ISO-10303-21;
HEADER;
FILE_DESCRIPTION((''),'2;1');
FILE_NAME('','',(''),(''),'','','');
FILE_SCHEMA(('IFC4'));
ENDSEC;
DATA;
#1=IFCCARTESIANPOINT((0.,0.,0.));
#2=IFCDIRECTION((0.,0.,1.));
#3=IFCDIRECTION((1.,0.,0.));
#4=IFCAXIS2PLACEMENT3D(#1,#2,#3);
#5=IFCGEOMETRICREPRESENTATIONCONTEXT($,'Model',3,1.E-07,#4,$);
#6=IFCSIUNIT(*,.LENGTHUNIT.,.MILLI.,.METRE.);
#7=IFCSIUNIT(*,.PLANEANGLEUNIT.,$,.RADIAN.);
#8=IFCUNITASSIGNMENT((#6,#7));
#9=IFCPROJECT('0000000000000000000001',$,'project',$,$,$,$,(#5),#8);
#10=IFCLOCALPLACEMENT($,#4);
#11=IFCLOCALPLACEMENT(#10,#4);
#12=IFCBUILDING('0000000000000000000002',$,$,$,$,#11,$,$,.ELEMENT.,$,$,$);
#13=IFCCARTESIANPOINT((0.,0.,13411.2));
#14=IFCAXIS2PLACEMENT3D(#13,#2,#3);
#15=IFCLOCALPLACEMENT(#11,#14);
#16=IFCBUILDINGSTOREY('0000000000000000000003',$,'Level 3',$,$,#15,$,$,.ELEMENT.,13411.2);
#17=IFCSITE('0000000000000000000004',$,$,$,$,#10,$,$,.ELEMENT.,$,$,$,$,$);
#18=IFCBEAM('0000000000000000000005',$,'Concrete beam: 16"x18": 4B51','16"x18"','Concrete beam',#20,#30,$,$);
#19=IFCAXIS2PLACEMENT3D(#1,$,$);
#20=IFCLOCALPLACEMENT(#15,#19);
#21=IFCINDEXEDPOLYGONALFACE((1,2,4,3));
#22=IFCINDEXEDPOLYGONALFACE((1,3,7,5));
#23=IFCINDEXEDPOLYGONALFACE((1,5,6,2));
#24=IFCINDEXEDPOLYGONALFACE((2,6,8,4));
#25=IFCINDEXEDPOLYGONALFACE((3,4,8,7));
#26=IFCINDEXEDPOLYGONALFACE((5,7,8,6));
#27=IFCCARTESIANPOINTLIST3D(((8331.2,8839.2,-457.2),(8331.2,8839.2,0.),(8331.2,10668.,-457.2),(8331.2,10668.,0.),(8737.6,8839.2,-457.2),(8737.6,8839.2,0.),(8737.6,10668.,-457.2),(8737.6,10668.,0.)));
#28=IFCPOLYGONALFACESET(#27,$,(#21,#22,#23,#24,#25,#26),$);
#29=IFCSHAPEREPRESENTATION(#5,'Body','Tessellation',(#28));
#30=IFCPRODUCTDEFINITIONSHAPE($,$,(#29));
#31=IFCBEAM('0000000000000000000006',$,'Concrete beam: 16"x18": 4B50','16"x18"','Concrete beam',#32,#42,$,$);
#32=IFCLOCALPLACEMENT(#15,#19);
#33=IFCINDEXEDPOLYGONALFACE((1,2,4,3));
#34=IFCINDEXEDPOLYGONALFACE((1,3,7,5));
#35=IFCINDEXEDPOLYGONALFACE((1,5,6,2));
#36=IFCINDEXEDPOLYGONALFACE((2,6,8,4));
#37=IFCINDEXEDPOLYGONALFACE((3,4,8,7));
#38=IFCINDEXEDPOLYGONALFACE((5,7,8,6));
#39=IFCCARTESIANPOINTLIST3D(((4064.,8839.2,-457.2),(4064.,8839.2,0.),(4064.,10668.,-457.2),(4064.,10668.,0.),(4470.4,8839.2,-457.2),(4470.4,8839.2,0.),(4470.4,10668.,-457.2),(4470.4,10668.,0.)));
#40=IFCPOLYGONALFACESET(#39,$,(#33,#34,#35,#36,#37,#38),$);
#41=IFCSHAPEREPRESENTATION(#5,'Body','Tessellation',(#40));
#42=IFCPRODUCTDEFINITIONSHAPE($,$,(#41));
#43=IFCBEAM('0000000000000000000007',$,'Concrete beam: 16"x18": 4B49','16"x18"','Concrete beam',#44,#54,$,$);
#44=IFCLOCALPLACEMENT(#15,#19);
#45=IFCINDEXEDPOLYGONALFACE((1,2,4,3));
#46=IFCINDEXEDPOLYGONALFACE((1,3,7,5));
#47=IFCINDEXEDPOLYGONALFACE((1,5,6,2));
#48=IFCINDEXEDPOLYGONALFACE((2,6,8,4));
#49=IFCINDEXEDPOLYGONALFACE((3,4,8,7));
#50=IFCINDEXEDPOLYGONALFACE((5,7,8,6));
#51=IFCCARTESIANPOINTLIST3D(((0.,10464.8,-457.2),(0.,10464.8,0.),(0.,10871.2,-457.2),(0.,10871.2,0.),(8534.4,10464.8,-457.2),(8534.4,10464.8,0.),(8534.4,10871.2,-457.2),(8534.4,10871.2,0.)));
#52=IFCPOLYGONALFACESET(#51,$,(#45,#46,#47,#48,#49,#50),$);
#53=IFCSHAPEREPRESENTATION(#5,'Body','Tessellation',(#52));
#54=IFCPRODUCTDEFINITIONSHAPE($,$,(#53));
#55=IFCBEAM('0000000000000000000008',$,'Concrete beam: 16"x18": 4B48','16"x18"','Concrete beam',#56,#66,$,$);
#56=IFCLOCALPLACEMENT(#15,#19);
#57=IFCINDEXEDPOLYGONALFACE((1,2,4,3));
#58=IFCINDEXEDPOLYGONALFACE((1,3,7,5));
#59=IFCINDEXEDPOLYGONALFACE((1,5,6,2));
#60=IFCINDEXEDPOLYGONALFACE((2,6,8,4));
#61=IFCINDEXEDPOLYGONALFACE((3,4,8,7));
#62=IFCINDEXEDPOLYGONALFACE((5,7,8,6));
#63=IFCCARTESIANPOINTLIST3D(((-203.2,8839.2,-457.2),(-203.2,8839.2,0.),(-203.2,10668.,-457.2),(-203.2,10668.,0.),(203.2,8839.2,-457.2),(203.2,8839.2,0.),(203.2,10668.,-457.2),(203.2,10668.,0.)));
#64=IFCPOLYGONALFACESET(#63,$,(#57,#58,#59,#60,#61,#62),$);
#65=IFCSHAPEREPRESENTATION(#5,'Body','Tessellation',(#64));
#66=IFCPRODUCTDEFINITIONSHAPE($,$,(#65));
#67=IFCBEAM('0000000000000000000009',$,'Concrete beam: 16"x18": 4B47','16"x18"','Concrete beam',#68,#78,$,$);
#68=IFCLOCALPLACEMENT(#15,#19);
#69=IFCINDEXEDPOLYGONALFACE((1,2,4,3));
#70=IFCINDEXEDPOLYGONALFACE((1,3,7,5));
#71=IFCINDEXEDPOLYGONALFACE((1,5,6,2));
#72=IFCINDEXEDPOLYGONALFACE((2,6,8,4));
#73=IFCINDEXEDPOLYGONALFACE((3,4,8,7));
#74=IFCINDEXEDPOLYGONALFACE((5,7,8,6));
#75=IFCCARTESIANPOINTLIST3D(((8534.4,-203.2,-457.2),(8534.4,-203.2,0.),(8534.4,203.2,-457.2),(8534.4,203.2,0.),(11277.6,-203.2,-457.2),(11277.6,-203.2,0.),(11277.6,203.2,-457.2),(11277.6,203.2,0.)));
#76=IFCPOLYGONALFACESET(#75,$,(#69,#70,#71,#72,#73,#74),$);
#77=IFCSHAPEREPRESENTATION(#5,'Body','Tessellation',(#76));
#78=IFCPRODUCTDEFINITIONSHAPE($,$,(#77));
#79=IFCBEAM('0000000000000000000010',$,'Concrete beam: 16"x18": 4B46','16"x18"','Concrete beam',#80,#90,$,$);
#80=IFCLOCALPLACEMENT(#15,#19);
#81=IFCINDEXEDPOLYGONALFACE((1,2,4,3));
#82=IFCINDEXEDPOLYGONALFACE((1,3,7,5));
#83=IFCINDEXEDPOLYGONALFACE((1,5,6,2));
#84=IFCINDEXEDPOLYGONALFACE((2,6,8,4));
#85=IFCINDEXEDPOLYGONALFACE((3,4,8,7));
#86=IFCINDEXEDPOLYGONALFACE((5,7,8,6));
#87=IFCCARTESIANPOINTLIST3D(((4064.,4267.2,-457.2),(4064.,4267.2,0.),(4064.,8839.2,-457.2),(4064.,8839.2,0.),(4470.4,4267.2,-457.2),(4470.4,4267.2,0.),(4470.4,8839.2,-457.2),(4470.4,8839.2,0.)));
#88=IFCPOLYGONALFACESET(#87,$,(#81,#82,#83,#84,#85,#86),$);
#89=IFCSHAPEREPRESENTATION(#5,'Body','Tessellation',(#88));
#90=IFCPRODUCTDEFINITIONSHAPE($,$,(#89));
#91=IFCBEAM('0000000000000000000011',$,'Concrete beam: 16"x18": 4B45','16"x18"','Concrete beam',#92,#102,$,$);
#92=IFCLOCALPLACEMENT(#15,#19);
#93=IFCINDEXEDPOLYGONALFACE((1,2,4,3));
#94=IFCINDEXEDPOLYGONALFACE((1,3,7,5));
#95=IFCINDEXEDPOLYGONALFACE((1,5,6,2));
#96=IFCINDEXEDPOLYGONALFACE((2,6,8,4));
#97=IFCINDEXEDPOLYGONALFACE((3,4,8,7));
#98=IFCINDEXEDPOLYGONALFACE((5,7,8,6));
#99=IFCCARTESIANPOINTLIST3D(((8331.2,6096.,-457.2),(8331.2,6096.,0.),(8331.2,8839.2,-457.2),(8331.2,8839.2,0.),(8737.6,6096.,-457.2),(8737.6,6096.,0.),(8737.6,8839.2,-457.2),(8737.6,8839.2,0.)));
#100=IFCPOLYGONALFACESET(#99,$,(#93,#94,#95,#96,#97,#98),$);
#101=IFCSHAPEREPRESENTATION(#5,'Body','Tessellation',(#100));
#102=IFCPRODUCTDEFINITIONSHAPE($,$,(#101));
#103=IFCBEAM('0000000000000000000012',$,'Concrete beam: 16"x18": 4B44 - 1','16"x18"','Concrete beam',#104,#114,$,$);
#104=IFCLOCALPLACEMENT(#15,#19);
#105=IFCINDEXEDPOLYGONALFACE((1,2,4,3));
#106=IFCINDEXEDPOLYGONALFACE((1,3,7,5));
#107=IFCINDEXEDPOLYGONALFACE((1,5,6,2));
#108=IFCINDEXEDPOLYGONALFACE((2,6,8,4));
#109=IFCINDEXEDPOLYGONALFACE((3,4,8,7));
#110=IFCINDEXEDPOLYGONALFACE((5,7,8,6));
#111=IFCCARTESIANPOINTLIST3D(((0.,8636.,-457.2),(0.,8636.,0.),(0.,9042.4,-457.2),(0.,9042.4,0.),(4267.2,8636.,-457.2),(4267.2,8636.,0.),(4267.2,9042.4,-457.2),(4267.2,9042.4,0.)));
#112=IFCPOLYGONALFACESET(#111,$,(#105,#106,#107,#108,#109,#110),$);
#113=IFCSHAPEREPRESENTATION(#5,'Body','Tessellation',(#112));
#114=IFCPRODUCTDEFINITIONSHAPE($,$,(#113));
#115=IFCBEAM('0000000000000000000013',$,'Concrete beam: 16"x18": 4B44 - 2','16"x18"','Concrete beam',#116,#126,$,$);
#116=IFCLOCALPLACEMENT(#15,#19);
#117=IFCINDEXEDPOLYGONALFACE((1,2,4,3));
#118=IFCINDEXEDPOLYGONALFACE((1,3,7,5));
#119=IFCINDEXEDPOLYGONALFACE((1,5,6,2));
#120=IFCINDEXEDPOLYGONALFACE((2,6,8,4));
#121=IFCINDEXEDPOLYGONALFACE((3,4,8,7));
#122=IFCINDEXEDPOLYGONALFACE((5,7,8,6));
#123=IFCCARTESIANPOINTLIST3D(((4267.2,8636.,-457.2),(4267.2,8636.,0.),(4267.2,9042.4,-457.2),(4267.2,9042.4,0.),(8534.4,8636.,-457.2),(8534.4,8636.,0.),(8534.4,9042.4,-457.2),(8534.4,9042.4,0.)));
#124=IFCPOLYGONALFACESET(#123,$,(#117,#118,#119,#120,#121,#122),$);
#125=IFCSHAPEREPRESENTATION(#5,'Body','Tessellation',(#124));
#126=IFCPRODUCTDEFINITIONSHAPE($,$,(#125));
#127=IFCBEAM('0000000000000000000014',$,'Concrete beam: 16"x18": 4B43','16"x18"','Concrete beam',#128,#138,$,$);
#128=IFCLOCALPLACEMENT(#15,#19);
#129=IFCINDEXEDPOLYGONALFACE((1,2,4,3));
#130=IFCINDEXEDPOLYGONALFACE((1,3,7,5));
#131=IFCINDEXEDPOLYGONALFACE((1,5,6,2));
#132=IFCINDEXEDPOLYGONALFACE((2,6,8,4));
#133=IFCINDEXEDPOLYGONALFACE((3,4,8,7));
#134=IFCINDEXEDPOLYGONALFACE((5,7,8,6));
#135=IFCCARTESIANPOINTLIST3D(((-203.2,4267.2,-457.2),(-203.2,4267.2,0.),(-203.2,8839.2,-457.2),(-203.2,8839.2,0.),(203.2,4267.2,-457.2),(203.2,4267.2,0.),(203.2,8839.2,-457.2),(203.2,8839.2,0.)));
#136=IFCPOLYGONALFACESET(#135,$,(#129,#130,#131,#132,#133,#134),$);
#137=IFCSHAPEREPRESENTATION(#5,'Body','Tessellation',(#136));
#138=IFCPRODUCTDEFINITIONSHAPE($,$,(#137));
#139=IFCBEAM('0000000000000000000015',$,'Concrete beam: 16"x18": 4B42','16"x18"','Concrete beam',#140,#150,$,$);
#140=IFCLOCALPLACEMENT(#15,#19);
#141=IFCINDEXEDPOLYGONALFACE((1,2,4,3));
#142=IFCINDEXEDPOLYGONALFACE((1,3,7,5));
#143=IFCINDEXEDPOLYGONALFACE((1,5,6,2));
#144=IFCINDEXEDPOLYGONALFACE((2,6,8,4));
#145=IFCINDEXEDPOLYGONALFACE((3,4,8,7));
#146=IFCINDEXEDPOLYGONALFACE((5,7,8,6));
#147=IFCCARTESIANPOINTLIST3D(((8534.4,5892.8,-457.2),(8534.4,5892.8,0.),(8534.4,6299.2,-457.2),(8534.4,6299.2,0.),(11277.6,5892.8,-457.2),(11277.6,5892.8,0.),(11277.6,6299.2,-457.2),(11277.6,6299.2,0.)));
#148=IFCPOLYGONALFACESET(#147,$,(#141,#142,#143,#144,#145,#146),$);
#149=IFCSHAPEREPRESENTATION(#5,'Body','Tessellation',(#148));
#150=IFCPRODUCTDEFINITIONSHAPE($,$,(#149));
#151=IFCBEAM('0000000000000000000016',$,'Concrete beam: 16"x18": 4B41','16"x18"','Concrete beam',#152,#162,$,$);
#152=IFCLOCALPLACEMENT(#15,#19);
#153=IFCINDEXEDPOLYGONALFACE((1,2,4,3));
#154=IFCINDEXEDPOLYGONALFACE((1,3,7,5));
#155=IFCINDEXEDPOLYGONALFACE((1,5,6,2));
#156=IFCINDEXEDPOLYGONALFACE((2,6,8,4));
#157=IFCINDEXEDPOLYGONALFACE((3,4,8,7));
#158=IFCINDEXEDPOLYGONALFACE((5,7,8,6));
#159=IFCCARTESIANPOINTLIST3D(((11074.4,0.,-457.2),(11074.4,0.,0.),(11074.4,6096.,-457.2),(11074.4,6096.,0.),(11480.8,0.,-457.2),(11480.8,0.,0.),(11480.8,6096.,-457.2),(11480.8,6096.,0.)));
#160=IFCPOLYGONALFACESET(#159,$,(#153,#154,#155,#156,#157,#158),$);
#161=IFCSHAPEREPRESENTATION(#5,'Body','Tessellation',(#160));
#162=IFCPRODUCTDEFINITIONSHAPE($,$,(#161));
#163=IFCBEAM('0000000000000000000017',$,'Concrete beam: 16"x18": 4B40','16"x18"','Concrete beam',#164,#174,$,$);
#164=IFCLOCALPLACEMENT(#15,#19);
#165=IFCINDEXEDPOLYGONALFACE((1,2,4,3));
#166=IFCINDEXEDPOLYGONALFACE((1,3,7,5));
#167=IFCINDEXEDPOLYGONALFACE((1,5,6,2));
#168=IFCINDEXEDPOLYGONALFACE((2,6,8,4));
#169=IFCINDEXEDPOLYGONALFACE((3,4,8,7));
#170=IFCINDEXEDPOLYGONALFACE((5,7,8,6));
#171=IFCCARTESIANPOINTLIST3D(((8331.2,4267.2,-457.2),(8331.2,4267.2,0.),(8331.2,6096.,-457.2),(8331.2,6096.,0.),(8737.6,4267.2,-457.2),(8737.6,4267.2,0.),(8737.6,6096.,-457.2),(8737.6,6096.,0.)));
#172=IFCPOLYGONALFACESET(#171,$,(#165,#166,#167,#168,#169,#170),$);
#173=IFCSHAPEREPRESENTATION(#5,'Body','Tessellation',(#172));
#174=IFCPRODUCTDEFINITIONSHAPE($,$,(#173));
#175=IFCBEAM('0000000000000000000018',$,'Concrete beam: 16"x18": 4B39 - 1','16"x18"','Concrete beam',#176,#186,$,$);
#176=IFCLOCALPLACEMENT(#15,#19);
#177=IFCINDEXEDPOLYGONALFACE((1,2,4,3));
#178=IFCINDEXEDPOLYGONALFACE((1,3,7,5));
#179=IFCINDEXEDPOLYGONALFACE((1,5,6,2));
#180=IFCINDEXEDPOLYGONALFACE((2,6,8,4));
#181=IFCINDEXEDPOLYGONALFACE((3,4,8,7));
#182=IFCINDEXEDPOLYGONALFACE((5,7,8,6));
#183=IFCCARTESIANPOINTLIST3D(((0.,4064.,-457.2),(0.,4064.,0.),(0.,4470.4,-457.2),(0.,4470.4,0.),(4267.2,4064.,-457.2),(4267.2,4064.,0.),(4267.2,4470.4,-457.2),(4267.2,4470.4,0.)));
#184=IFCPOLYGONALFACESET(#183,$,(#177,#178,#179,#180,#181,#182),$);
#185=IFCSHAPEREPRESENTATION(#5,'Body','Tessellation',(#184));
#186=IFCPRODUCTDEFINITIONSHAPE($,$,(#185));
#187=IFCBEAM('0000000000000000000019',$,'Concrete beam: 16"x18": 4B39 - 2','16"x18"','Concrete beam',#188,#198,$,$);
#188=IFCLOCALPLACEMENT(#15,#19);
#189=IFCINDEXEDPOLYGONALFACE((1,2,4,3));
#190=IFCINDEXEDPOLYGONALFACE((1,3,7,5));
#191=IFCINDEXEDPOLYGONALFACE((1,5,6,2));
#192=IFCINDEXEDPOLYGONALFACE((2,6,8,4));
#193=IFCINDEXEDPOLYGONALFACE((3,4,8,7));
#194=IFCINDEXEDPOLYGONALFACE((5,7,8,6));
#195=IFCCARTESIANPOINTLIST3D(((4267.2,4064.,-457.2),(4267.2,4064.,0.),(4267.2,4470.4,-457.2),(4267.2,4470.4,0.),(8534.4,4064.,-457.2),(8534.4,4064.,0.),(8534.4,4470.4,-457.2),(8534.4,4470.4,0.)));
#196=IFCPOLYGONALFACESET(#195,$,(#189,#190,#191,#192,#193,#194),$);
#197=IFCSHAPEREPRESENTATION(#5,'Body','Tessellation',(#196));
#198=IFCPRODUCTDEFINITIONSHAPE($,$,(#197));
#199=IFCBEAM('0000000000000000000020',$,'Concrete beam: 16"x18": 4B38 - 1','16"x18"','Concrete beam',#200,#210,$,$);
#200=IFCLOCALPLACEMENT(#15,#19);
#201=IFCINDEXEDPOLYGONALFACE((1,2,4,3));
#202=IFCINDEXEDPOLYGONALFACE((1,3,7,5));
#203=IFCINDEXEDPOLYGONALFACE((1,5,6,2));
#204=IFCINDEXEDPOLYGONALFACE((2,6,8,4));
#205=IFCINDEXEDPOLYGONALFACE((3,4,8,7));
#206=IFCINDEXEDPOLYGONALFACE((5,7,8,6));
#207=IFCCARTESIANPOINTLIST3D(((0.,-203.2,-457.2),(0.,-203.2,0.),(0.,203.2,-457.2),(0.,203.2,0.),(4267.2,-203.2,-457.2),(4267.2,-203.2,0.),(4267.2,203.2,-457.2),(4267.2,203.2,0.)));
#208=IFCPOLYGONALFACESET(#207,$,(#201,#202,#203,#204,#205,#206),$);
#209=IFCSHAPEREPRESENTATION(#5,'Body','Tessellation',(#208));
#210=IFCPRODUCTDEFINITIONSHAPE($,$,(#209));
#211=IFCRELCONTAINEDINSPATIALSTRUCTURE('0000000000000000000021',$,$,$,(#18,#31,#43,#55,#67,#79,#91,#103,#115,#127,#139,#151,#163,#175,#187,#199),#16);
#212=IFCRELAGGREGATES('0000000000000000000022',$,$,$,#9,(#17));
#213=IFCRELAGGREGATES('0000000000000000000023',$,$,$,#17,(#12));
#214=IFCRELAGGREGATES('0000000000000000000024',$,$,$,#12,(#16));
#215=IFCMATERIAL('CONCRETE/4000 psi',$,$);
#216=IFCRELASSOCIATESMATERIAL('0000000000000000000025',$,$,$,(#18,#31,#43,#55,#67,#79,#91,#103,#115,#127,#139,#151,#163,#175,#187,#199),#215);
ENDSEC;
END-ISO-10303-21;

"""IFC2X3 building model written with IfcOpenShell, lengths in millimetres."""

from ifc_helpers import new_model, si_unit, frame, origin_with_axes, origin_2d_with_axis, place, context, project, spatial, rectangle, extrude, material, element, save


model = new_model("IFC2X3")

# Units and contexts
model_context = context("Model", 3, precision=1e-07, world=origin_with_axes())
ifc_project = project(units=[si_unit("LENGTHUNIT", "METRE", prefix="MILLI"), si_unit("PLANEANGLEUNIT", "RADIAN")], contexts=[model_context])

# Site, building, storey
site_placement = place(None, origin_with_axes())
site = spatial("IfcSite", under=ifc_project, at=site_placement, CompositionType="ELEMENT")
building_placement = place(site_placement, origin_with_axes())
building = spatial("IfcBuilding", under=site, at=building_placement, CompositionType="ELEMENT")
storey_placement = place(building_placement, frame((0.0, 0.0, 13411.2), z_axis=(0.0, 0.0, 1.0), x_axis=(1.0, 0.0, 0.0)))
storey = spatial("IfcBuildingStorey", under=building, at=storey_placement, Name="Level 3", CompositionType="ELEMENT", Elevation=13411.2)

# Beams
ifc_material = material(Name="CONCRETE/4000 psi")
for number, where, z_axis, x_axis, name in (
    (1, (8534.4, 10668.0, 13411.2), (0.0, 0.0, 1.0), (0.0, -1.0, 0.0), "Concrete beam: 16\"x18\": 4B51"),
    (2, (4267.2, 10668.0, 13411.2), (0.0, 0.0, 1.0), (0.0, -1.0, 0.0), "Concrete beam: 16\"x18\": 4B50"),
):
    element("IfcBeam", number, at=place(building_placement, frame(where, z_axis=z_axis, x_axis=x_axis)), inside=storey, material=ifc_material, Name=name, Description="16\"x18\"", ObjectType="Concrete beam", context=model_context, shape_type="SweptSolid", body=[
        extrude(rectangle(XDim=406.4, YDim=457.2, at=origin_2d_with_axis()), frame((1828.8, 0.0, -228.6), z_axis=(-1.0, 0.0, 0.0), x_axis=(0.0, -1.0, 0.0)), (0.0, 0.0, 1.0), 1828.8),
    ])
beam_1_placement = place(building_placement, frame((0.0, 10668.0, 13411.2), z_axis=(0.0, 0.0, 1.0), x_axis=(1.0, 0.0, 0.0)))
element("IfcBeam", 3, at=beam_1_placement, inside=storey, material=ifc_material, Name="Concrete beam: 16\"x18\": 4B49", Description="16\"x18\"", ObjectType="Concrete beam", context=model_context, shape_type="SweptSolid", body=[
    extrude(rectangle(XDim=406.4, YDim=457.2, at=origin_2d_with_axis()), frame((8534.4, 0.0, -228.6), z_axis=(-1.0, 0.0, 0.0), x_axis=(0.0, -1.0, 0.0)), (0.0, 0.0, 1.0), 8534.4),
])
beam_2_placement = place(building_placement, frame((0.0, 10668.0, 13411.2), z_axis=(0.0, 0.0, 1.0), x_axis=(0.0, -1.0, 0.0)))
element("IfcBeam", 4, at=beam_2_placement, inside=storey, material=ifc_material, Name="Concrete beam: 16\"x18\": 4B48", Description="16\"x18\"", ObjectType="Concrete beam", context=model_context, shape_type="SweptSolid", body=[
    extrude(rectangle(XDim=406.4, YDim=457.2, at=origin_2d_with_axis()), frame((1828.8, 0.0, -228.6), z_axis=(-1.0, 0.0, 0.0), x_axis=(0.0, -1.0, 0.0)), (0.0, 0.0, 1.0), 1828.8),
])
beam_3_placement = place(building_placement, frame((8534.4, 0.0, 13411.2), z_axis=(0.0, 0.0, 1.0), x_axis=(1.0, 0.0, 0.0)))
element("IfcBeam", 5, at=beam_3_placement, inside=storey, material=ifc_material, Name="Concrete beam: 16\"x18\": 4B47", Description="16\"x18\"", ObjectType="Concrete beam", context=model_context, shape_type="SweptSolid", body=[
    extrude(rectangle(XDim=406.4, YDim=457.2, at=origin_2d_with_axis()), frame((2743.2, 0.0, -228.6), z_axis=(-1.0, 0.0, 0.0), x_axis=(0.0, -1.0, 0.0)), (0.0, 0.0, 1.0), 2743.2),
])
beam_4_placement = place(building_placement, frame((4267.2, 4267.2, 13411.2), z_axis=(0.0, 0.0, 1.0), x_axis=(0.0, 1.0, 0.0)))
element("IfcBeam", 6, at=beam_4_placement, inside=storey, material=ifc_material, Name="Concrete beam: 16\"x18\": 4B46", Description="16\"x18\"", ObjectType="Concrete beam", context=model_context, shape_type="SweptSolid", body=[
    extrude(rectangle(XDim=406.4, YDim=457.2, at=origin_2d_with_axis()), frame((4572.0, 0.0, -228.6), z_axis=(-1.0, 0.0, 0.0), x_axis=(0.0, -1.0, 0.0)), (0.0, 0.0, 1.0), 4572.0),
])
beam_5_placement = place(building_placement, frame((8534.4, 6096.0, 13411.2), z_axis=(0.0, 0.0, 1.0), x_axis=(0.0, 1.0, 0.0)))
element("IfcBeam", 7, at=beam_5_placement, inside=storey, material=ifc_material, Name="Concrete beam: 16\"x18\": 4B45", Description="16\"x18\"", ObjectType="Concrete beam", context=model_context, shape_type="SweptSolid", body=[
    extrude(rectangle(XDim=406.4, YDim=457.2, at=origin_2d_with_axis()), frame((2743.2, 0.0, -228.6), z_axis=(-1.0, 0.0, 0.0), x_axis=(0.0, -1.0, 0.0)), (0.0, 0.0, 1.0), 2743.2),
])
for number, where, z_axis, x_axis, name in (
    (8, (0.0, 8839.2, 13411.2), (0.0, 0.0, 1.0), (1.0, 0.0, 0.0), "Concrete beam: 16\"x18\": 4B44 - 1"),
    (9, (4267.2, 8839.2, 13411.2), (0.0, 0.0, 1.0), (1.0, 0.0, 0.0), "Concrete beam: 16\"x18\": 4B44 - 2"),
):
    element("IfcBeam", number, at=place(building_placement, frame(where, z_axis=z_axis, x_axis=x_axis)), inside=storey, material=ifc_material, Name=name, Description="16\"x18\"", ObjectType="Concrete beam", context=model_context, shape_type="SweptSolid", body=[
        extrude(rectangle(XDim=406.4, YDim=457.2, at=origin_2d_with_axis()), frame((4267.2, 0.0, -228.6), z_axis=(-1.0, 0.0, 0.0), x_axis=(0.0, -1.0, 0.0)), (0.0, 0.0, 1.0), 4267.2),
    ])
beam_6_placement = place(building_placement, frame((0.0, 4267.2, 13411.2), z_axis=(0.0, 0.0, 1.0), x_axis=(0.0, 1.0, 0.0)))
element("IfcBeam", 10, at=beam_6_placement, inside=storey, material=ifc_material, Name="Concrete beam: 16\"x18\": 4B43", Description="16\"x18\"", ObjectType="Concrete beam", context=model_context, shape_type="SweptSolid", body=[
    extrude(rectangle(XDim=406.4, YDim=457.2, at=origin_2d_with_axis()), frame((4572.0, 0.0, -228.6), z_axis=(-1.0, 0.0, 0.0), x_axis=(0.0, -1.0, 0.0)), (0.0, 0.0, 1.0), 4572.0),
])
beam_7_placement = place(building_placement, frame((8534.4, 6096.0, 13411.2), z_axis=(0.0, 0.0, 1.0), x_axis=(1.0, 0.0, 0.0)))
element("IfcBeam", 11, at=beam_7_placement, inside=storey, material=ifc_material, Name="Concrete beam: 16\"x18\": 4B42", Description="16\"x18\"", ObjectType="Concrete beam", context=model_context, shape_type="SweptSolid", body=[
    extrude(rectangle(XDim=406.4, YDim=457.2, at=origin_2d_with_axis()), frame((2743.2, 0.0, -228.6), z_axis=(-1.0, 0.0, 0.0), x_axis=(0.0, -1.0, 0.0)), (0.0, 0.0, 1.0), 2743.2),
])
beam_8_placement = place(building_placement, frame((11277.6, 0.0, 13411.2), z_axis=(0.0, 0.0, 1.0), x_axis=(0.0, 1.0, 0.0)))
element("IfcBeam", 12, at=beam_8_placement, inside=storey, material=ifc_material, Name="Concrete beam: 16\"x18\": 4B41", Description="16\"x18\"", ObjectType="Concrete beam", context=model_context, shape_type="SweptSolid", body=[
    extrude(rectangle(XDim=406.4, YDim=457.2, at=origin_2d_with_axis()), frame((6096.0, 0.0, -228.6), z_axis=(-1.0, 0.0, 0.0), x_axis=(0.0, -1.0, 0.0)), (0.0, 0.0, 1.0), 6096.0),
])
beam_9_placement = place(building_placement, frame((8534.4, 4267.2, 13411.2), z_axis=(0.0, 0.0, 1.0), x_axis=(0.0, 1.0, 0.0)))
element("IfcBeam", 13, at=beam_9_placement, inside=storey, material=ifc_material, Name="Concrete beam: 16\"x18\": 4B40", Description="16\"x18\"", ObjectType="Concrete beam", context=model_context, shape_type="SweptSolid", body=[
    extrude(rectangle(XDim=406.4, YDim=457.2, at=origin_2d_with_axis()), frame((1828.8, 0.0, -228.6), z_axis=(-1.0, 0.0, 0.0), x_axis=(0.0, -1.0, 0.0)), (0.0, 0.0, 1.0), 1828.8),
])
for number, where, z_axis, x_axis, name in (
    (14, (0.0, 4267.2, 13411.2), (0.0, 0.0, 1.0), (1.0, 0.0, 0.0), "Concrete beam: 16\"x18\": 4B39 - 1"),
    (15, (4267.2, 4267.2, 13411.2), (0.0, 0.0, 1.0), (1.0, 0.0, 0.0), "Concrete beam: 16\"x18\": 4B39 - 2"),
    (16, (0.0, 0.0, 13411.2), (0.0, 0.0, 1.0), (1.0, 0.0, 0.0), "Concrete beam: 16\"x18\": 4B38 - 1"),
):
    element("IfcBeam", number, at=place(building_placement, frame(where, z_axis=z_axis, x_axis=x_axis)), inside=storey, material=ifc_material, Name=name, Description="16\"x18\"", ObjectType="Concrete beam", context=model_context, shape_type="SweptSolid", body=[
        extrude(rectangle(XDim=406.4, YDim=457.2, at=origin_2d_with_axis()), frame((4267.2, 0.0, -228.6), z_axis=(-1.0, 0.0, 0.0), x_axis=(0.0, -1.0, 0.0)), (0.0, 0.0, 1.0), 4267.2),
    ])

save(model, "model.ifc")
